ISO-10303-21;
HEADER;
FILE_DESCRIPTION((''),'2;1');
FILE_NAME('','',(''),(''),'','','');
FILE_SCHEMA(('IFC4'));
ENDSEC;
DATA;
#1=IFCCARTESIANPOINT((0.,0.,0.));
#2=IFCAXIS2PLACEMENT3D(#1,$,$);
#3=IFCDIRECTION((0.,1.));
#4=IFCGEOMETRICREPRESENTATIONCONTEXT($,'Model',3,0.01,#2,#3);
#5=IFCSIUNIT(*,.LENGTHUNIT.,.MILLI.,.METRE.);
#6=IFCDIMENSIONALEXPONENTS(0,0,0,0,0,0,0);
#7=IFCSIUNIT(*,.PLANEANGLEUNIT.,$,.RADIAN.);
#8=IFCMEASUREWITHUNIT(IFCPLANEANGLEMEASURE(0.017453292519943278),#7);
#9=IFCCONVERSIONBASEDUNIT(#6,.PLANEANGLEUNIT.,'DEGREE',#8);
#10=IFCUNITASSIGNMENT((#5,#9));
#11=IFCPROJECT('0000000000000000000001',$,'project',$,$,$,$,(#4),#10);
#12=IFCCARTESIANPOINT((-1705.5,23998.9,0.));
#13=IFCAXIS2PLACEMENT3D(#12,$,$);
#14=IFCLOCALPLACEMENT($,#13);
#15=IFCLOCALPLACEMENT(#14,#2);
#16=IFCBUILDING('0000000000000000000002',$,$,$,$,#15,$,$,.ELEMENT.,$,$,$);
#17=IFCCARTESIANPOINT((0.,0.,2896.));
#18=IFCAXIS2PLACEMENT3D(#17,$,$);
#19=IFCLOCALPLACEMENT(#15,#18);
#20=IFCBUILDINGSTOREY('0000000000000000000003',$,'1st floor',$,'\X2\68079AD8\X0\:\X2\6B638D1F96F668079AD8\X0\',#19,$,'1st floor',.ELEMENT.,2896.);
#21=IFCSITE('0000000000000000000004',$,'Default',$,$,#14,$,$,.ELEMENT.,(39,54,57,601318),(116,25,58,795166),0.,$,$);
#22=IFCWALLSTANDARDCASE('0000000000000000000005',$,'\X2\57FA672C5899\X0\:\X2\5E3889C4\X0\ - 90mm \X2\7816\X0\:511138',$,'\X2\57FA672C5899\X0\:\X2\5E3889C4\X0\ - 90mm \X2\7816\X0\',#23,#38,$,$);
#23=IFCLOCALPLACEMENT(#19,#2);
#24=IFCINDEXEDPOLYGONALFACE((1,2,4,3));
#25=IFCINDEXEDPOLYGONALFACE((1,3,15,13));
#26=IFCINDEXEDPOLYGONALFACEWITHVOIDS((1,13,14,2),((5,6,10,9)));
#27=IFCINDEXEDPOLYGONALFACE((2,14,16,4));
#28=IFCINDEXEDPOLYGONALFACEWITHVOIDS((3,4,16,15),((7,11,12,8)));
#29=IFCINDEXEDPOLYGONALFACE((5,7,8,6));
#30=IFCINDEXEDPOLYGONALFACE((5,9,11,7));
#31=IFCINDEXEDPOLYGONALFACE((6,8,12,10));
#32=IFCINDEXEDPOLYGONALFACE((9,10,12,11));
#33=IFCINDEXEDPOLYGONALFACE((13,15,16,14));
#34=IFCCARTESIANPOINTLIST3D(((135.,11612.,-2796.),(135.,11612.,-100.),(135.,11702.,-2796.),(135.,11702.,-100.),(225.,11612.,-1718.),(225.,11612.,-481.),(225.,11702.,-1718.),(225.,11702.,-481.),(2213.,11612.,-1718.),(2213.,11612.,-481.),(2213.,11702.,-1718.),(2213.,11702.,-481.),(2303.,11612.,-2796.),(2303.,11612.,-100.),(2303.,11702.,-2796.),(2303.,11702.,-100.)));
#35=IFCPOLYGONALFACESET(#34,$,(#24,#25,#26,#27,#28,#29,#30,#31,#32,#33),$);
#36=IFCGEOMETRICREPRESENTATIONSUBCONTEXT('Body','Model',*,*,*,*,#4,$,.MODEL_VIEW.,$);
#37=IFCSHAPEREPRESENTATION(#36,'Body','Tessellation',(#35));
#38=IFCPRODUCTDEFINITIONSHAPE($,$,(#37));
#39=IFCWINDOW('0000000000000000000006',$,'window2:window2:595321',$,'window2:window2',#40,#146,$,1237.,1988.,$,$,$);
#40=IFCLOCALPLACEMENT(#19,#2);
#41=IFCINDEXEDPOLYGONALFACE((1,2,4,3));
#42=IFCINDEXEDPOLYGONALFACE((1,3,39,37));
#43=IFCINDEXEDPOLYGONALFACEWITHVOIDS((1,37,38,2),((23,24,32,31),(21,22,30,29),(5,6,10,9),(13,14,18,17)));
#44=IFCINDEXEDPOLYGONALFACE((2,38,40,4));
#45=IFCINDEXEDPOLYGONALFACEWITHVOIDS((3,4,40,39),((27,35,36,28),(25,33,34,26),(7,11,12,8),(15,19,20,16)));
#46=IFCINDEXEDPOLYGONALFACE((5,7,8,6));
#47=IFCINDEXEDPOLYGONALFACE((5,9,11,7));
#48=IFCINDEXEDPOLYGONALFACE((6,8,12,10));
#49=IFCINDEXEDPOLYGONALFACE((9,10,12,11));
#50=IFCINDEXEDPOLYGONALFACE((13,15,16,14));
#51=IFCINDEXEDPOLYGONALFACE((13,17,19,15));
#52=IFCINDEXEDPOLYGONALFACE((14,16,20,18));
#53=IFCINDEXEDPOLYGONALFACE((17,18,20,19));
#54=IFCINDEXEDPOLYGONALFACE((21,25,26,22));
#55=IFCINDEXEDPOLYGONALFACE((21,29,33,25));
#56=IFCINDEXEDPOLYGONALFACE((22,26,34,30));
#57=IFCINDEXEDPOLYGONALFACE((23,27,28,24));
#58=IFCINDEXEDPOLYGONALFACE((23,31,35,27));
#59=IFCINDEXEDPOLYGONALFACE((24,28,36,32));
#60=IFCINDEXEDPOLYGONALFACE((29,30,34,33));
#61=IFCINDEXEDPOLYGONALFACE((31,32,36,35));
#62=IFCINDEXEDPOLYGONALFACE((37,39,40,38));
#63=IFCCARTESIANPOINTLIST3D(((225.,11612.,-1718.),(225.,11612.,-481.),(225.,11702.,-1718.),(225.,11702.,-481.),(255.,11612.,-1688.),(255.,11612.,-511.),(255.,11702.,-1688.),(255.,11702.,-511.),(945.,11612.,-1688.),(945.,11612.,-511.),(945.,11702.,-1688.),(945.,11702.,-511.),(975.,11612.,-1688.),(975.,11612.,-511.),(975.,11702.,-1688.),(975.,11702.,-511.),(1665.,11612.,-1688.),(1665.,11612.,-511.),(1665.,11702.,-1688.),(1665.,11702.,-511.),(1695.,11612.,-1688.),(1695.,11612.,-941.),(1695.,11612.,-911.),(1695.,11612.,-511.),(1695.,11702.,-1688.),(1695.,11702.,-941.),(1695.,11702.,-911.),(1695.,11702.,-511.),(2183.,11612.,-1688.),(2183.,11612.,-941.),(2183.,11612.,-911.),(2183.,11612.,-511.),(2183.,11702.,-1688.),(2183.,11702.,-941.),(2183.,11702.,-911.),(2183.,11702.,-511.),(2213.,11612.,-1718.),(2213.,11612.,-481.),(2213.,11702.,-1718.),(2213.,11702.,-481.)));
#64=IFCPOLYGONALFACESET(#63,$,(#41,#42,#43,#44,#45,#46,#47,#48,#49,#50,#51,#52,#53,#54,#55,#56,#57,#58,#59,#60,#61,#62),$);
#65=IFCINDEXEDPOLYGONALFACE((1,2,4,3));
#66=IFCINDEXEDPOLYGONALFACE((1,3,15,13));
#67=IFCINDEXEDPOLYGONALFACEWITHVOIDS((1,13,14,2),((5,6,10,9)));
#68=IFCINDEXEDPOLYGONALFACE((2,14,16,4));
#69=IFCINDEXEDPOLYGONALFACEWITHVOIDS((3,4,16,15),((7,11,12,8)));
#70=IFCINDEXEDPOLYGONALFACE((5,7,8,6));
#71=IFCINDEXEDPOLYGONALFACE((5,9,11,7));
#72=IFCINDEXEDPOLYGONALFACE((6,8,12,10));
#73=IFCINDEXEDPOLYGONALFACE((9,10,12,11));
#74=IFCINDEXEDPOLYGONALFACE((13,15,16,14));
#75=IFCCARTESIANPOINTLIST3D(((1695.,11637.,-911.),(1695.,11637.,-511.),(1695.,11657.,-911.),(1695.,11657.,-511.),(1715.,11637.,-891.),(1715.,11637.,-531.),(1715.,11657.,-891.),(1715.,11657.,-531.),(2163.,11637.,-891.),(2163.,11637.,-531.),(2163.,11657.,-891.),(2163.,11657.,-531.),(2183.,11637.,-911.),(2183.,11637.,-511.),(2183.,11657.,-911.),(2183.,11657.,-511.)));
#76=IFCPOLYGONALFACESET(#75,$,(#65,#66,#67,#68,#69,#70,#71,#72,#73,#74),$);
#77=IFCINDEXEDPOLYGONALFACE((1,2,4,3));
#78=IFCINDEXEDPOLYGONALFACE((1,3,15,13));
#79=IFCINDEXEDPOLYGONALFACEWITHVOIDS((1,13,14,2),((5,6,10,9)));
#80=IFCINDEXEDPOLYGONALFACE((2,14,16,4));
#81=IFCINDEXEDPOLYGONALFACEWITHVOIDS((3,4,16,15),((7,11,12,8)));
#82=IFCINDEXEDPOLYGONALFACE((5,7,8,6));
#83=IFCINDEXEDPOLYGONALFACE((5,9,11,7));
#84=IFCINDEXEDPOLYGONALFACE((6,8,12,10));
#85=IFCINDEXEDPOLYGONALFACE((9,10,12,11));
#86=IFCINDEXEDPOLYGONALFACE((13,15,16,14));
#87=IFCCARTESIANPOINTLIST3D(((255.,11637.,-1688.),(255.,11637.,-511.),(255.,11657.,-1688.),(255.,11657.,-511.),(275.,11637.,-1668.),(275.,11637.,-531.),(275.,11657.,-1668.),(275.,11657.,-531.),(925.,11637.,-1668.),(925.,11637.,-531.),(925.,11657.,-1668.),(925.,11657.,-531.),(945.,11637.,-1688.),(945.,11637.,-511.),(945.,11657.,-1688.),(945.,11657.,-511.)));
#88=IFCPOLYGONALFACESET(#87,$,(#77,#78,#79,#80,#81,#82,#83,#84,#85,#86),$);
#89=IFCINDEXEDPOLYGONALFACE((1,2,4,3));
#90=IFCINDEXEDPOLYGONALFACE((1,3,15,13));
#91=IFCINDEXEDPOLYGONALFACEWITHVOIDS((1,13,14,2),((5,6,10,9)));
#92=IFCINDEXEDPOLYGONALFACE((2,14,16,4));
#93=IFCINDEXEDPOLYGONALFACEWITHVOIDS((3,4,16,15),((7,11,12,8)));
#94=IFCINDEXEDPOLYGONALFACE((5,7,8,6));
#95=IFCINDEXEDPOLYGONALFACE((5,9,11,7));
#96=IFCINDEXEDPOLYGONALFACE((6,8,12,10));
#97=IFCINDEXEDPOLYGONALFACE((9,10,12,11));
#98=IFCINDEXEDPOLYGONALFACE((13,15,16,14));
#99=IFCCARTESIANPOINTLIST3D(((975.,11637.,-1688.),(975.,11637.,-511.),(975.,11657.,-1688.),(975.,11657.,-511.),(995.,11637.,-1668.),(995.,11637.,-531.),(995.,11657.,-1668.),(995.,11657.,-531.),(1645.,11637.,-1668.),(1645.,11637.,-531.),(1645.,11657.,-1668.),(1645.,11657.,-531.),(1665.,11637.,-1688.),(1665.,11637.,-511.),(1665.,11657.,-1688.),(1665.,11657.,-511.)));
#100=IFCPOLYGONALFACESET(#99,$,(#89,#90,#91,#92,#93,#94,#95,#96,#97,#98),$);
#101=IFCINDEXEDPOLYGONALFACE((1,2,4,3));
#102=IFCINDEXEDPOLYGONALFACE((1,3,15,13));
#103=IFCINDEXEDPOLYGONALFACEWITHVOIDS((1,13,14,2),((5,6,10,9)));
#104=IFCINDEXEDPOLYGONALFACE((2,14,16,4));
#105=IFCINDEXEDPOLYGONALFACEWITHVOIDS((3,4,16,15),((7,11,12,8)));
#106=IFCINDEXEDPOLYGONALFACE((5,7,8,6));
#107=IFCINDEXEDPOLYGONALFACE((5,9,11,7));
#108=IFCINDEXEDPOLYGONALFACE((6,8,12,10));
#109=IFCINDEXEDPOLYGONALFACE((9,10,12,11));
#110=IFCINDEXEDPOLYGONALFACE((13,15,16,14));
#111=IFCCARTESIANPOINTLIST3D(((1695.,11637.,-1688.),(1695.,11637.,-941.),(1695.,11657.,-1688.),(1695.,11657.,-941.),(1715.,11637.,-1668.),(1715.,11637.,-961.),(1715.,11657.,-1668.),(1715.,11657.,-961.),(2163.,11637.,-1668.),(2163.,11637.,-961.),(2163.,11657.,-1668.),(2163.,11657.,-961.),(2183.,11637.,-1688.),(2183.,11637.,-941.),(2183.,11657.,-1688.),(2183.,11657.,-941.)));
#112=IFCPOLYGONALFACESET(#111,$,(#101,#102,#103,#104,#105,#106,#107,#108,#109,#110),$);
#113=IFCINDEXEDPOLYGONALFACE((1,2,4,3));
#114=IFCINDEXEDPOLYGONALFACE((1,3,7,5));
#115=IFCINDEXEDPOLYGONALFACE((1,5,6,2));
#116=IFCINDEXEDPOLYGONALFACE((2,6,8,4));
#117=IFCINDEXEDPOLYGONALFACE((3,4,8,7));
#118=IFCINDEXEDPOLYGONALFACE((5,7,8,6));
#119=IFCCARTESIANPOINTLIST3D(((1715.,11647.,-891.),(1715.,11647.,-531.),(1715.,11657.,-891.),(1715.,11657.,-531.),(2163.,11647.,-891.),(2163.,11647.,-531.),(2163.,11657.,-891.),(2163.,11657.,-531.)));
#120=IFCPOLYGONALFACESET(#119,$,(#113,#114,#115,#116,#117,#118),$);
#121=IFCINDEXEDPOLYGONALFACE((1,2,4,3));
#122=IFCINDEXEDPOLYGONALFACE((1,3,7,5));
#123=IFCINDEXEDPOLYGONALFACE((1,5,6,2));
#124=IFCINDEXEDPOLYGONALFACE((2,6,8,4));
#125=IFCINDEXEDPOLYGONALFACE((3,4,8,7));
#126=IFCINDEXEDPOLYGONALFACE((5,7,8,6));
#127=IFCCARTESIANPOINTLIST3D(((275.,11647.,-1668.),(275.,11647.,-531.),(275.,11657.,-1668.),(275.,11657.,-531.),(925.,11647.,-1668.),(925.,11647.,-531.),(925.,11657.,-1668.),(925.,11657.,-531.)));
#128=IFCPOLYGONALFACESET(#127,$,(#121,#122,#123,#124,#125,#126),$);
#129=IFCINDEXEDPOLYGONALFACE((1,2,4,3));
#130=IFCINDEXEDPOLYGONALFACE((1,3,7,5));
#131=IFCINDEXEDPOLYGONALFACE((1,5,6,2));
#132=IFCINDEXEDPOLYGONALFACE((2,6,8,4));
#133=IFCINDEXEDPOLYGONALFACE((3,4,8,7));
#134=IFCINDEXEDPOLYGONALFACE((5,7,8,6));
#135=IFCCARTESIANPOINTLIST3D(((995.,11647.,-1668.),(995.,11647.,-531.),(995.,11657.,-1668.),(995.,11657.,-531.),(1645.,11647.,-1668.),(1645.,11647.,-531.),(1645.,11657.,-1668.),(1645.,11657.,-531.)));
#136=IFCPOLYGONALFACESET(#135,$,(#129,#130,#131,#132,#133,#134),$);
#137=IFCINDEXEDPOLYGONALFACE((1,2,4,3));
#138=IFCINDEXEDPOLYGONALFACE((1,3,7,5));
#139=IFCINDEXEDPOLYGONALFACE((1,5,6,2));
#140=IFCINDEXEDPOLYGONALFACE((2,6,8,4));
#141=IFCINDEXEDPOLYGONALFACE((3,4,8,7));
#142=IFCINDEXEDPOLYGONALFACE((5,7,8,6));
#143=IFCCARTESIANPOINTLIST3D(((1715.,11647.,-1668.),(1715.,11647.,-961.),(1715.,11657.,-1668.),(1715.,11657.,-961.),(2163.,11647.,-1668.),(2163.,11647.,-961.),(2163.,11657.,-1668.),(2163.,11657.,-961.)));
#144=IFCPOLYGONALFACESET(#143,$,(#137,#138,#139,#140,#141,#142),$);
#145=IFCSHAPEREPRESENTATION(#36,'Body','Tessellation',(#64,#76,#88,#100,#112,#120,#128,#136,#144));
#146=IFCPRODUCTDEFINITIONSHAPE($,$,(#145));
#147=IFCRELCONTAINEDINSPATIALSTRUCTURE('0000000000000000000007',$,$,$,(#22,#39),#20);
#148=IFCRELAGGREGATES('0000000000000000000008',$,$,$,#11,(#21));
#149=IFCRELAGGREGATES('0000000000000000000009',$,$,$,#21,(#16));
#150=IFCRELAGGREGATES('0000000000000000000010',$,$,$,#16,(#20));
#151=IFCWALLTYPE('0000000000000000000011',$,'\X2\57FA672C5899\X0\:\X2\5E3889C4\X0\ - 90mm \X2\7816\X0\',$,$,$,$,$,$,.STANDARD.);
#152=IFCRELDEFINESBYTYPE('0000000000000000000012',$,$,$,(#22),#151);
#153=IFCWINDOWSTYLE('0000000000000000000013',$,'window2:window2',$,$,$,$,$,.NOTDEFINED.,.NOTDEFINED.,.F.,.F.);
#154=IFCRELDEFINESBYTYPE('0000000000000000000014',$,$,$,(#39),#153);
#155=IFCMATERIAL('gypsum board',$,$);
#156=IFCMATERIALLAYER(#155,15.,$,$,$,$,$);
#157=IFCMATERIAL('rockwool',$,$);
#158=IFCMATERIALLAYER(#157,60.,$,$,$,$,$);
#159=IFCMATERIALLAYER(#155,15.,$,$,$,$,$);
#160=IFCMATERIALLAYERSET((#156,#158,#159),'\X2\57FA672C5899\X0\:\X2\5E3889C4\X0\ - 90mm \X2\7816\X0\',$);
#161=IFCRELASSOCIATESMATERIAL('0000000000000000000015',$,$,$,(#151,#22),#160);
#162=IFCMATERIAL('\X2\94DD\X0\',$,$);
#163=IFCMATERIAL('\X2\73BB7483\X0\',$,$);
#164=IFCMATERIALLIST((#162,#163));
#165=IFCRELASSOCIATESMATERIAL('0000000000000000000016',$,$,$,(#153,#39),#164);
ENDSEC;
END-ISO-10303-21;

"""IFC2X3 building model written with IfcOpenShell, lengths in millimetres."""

from ifc_helpers import new_model, entity, si_unit, converted_unit, direction, frame, frame_2d, origin, origin_2d_with_axis, place, context, subcontext, project, spatial, polyline, rectangle, outline, extrude, source, transform, mapped, material, material_list, layer, layer_set, layer_usage, type_object, type_shapes, element, fill, save


model = new_model("IFC2X3")

# Units and contexts
model_context = context("Model", 3, precision=0.01, world=origin(), true_north=direction((0.0, 1.0)))
body_context = subcontext(model_context, "Body", "Model", "MODEL_VIEW")
ifc_project = project(units=[si_unit("LENGTHUNIT", "METRE", prefix="MILLI"), converted_unit("PLANEANGLEUNIT", "DEGREE", entity("IfcPlaneAngleMeasure", 0.017453292519943278), si_unit("PLANEANGLEUNIT", "RADIAN"), dimensions=[0, 0, 0, 0, 0, 0, 0])], contexts=[model_context])

# Site, building, storey
site_placement = place(None, frame((-1705.5, 23998.9, 0.0)))
site = spatial("IfcSite", under=ifc_project, at=site_placement, Name="Default", CompositionType="ELEMENT", RefLatitude=(39, 54, 57, 601318), RefLongitude=(116, 25, 58, 795166), RefElevation=0.0)
building_placement = place(site_placement, origin())
building = spatial("IfcBuilding", under=site, at=building_placement, CompositionType="ELEMENT")
storey_placement = place(building_placement, frame((0.0, 0.0, 2896.0)))
storey = spatial("IfcBuildingStorey", under=building, at=storey_placement, Name="1st floor", ObjectType="标高:正负零标高", LongName="1st floor", CompositionType="ELEMENT", Elevation=2896.0)

# Wall, opening, window
ifc_material_1 = material(Name="gypsum board")
ifc_layer_1 = layer(ifc_material_1, 15.0)
ifc_material_2 = material(Name="rockwool")
ifc_layer_2 = layer(ifc_material_2, 60.0)
ifc_layer_3 = layer(ifc_material_1, 15.0)
ifc_layer_set = layer_set([ifc_layer_1, ifc_layer_2, ifc_layer_3], Name="基本墙:常规 - 90mm 砖")
ifc_layer_usage = layer_usage(ifc_layer_set, "AXIS2", "NEGATIVE", 45.0)
wall_type = type_object("IfcWallType", Name="基本墙:常规 - 90mm 砖", PredefinedType="STANDARD", material=ifc_layer_set)
wall_placement = place(storey_placement, frame((2303.0, 11657.0, -2796.0), z_axis=(0.0, 0.0, 1.0), x_axis=(-1.0, 0.0, 0.0)))
wall = element("IfcWallStandardCase", 1, at=wall_placement, inside=storey, type_object=wall_type, material=ifc_layer_usage, Name="基本墙:常规 - 90mm 砖:511138", ObjectType="基本墙:常规 - 90mm 砖", context=body_context, shape_type="SweptSolid", body=[
    extrude(rectangle(XDim=2168.0, YDim=90.0, at=frame_2d((1084.0, 0.0), x_axis=(-1.0, 0.0))), origin(), (0.0, 0.0, 1.0), 2696.0),
])
opening_1_placement = place(wall_placement, frame((2078.0, 45.0, 1078.0)))
opening_1 = element("IfcOpeningElement", 2, at=opening_1_placement, cuts=wall, ObjectType="Opening", context=body_context, shape_type="SweptSolid", body=[
    extrude(rectangle(XDim=1237.0, YDim=1988.0, at=frame_2d((618.5, 994.0), x_axis=(1.0, 0.0))), frame((0.0, 0.0, 0.0), z_axis=(0.0, -1.0, 0.0), x_axis=(0.0, 0.0, 1.0)), (0.0, 0.0, 1.0), 90.0),
])
ifc_material_3 = material(Name="铝")
ifc_material_4 = material(Name="玻璃")
ifc_material_list = material_list([ifc_material_3, ifc_material_4])
window_style = type_object("IfcWindowStyle", Name="window2:window2", ConstructionType="NOTDEFINED", OperationType="NOTDEFINED", ParameterTakesPrecedence=False, Sizeable=False, material=ifc_material_list)
shared_shape_1 = source(origin(), body_context, "Body", "SweptSolid", [
    extrude(outline(polyline([(-994.0, -618.5), (994.0, -618.5), (994.0, 618.5), (-994.0, 618.5), (-994.0, -618.5)]), holes=[polyline([(-964.0, -588.5), (-964.0, 158.5), (-476.0, 158.5), (-476.0, -588.5), (-964.0, -588.5)]), polyline([(-446.0, 588.5), (244.0, 588.5), (244.0, -588.5), (-446.0, -588.5), (-446.0, 588.5)]), polyline([(274.0, 588.5), (964.0, 588.5), (964.0, -588.5), (274.0, -588.5), (274.0, 588.5)]), polyline([(-964.0, 588.5), (-476.0, 588.5), (-476.0, 188.5), (-964.0, 188.5), (-964.0, 588.5)])]), frame((994.0, 0.0, 618.5), z_axis=(0.0, 1.0, 0.0), x_axis=(-1.0, 0.0, 0.0)), (0.0, 0.0, 1.0), 90.0),
    extrude(outline(polyline([(-200.0, -244.0), (200.0, -244.0), (200.0, 244.0), (-200.0, 244.0), (-200.0, -244.0)]), holes=[polyline([(-180.0, -224.0), (-180.0, 224.0), (180.0, 224.0), (180.0, -224.0), (-180.0, -224.0)])]), frame((1714.0, 25.0, 1007.0), z_axis=(0.0, 1.0, 0.0), x_axis=(0.0, 0.0, -1.0)), (0.0, 0.0, 1.0), 20.0),
    extrude(outline(polyline([(-588.5, -345.0), (588.5, -345.0), (588.5, 345.0), (-588.5, 345.0), (-588.5, -345.0)]), holes=[polyline([(-568.5, -325.0), (-568.5, 325.0), (568.5, 325.0), (568.5, -325.0), (-568.5, -325.0)])]), frame((375.0, 25.0, 618.5), z_axis=(0.0, 1.0, 0.0), x_axis=(0.0, 0.0, -1.0)), (0.0, 0.0, 1.0), 20.0),
    extrude(outline(polyline([(-588.5, -345.0), (588.5, -345.0), (588.5, 345.0), (-588.5, 345.0), (-588.5, -345.0)]), holes=[polyline([(-568.5, -325.0), (-568.5, 325.0), (568.5, 325.0), (568.5, -325.0), (-568.5, -325.0)])]), frame((1095.0, 25.0, 618.5), z_axis=(0.0, 1.0, 0.0), x_axis=(0.0, 0.0, -1.0)), (0.0, 0.0, 1.0), 20.0),
    extrude(outline(polyline([(-373.5, -244.0), (373.5, -244.0), (373.5, 244.0), (-373.5, 244.0), (-373.5, -244.0)]), holes=[polyline([(-353.5, -224.0), (-353.5, 224.0), (353.5, 224.0), (353.5, -224.0), (-353.5, -224.0)])]), frame((1714.0, 25.0, 403.5), z_axis=(0.0, 1.0, 0.0), x_axis=(0.0, 0.0, -1.0)), (0.0, 0.0, 1.0), 20.0),
    extrude(rectangle(XDim=10.0, YDim=448.0, at=frame_2d((0.0, 0.0), x_axis=(1.0, 0.0))), frame((1714.0, 40.0, 827.0), z_axis=(0.0, 0.0, 1.0), x_axis=(0.0, 1.0, 0.0)), (0.0, 0.0, 1.0), 360.0),
    extrude(rectangle(XDim=10.0, YDim=650.0, at=origin_2d_with_axis()), frame((375.0, 40.0, 50.0), z_axis=(0.0, 0.0, 1.0), x_axis=(0.0, 1.0, 0.0)), (0.0, 0.0, 1.0), 1137.0),
    extrude(rectangle(XDim=10.0, YDim=650.0, at=frame_2d((0.0, 0.0), x_axis=(1.0, 0.0))), frame((1095.0, 40.0, 50.0), z_axis=(0.0, 0.0, 1.0), x_axis=(0.0, 1.0, 0.0)), (0.0, 0.0, 1.0), 1137.0),
    extrude(rectangle(XDim=10.0, YDim=448.0, at=frame_2d((0.0, 0.0), x_axis=(1.0, 0.0))), frame((1714.0, 40.0, 50.0), z_axis=(0.0, 0.0, 1.0), x_axis=(0.0, 1.0, 0.0)), (0.0, 0.0, 1.0), 707.0),
])
type_shapes(window_style, [shared_shape_1])
window_placement = place(opening_1_placement, frame((0.0, 0.0, 0.0), z_axis=(0.0, 0.0, 1.0), x_axis=(-1.0, 0.0, 0.0)))
window = element("IfcWindow", 3, at=window_placement, inside=storey, type_object=window_style, material=ifc_material_list, Name="window2:window2:595321", ObjectType="window2:window2", OverallHeight=1237.0, OverallWidth=1988.0, context=body_context, shape_type="MappedRepresentation", body=[
    mapped(shared_shape_1, transform((0.0, 0.0, 0.0), scale=1.0)),
])
fill(opening_1, window)

save(model, "model.ifc")
